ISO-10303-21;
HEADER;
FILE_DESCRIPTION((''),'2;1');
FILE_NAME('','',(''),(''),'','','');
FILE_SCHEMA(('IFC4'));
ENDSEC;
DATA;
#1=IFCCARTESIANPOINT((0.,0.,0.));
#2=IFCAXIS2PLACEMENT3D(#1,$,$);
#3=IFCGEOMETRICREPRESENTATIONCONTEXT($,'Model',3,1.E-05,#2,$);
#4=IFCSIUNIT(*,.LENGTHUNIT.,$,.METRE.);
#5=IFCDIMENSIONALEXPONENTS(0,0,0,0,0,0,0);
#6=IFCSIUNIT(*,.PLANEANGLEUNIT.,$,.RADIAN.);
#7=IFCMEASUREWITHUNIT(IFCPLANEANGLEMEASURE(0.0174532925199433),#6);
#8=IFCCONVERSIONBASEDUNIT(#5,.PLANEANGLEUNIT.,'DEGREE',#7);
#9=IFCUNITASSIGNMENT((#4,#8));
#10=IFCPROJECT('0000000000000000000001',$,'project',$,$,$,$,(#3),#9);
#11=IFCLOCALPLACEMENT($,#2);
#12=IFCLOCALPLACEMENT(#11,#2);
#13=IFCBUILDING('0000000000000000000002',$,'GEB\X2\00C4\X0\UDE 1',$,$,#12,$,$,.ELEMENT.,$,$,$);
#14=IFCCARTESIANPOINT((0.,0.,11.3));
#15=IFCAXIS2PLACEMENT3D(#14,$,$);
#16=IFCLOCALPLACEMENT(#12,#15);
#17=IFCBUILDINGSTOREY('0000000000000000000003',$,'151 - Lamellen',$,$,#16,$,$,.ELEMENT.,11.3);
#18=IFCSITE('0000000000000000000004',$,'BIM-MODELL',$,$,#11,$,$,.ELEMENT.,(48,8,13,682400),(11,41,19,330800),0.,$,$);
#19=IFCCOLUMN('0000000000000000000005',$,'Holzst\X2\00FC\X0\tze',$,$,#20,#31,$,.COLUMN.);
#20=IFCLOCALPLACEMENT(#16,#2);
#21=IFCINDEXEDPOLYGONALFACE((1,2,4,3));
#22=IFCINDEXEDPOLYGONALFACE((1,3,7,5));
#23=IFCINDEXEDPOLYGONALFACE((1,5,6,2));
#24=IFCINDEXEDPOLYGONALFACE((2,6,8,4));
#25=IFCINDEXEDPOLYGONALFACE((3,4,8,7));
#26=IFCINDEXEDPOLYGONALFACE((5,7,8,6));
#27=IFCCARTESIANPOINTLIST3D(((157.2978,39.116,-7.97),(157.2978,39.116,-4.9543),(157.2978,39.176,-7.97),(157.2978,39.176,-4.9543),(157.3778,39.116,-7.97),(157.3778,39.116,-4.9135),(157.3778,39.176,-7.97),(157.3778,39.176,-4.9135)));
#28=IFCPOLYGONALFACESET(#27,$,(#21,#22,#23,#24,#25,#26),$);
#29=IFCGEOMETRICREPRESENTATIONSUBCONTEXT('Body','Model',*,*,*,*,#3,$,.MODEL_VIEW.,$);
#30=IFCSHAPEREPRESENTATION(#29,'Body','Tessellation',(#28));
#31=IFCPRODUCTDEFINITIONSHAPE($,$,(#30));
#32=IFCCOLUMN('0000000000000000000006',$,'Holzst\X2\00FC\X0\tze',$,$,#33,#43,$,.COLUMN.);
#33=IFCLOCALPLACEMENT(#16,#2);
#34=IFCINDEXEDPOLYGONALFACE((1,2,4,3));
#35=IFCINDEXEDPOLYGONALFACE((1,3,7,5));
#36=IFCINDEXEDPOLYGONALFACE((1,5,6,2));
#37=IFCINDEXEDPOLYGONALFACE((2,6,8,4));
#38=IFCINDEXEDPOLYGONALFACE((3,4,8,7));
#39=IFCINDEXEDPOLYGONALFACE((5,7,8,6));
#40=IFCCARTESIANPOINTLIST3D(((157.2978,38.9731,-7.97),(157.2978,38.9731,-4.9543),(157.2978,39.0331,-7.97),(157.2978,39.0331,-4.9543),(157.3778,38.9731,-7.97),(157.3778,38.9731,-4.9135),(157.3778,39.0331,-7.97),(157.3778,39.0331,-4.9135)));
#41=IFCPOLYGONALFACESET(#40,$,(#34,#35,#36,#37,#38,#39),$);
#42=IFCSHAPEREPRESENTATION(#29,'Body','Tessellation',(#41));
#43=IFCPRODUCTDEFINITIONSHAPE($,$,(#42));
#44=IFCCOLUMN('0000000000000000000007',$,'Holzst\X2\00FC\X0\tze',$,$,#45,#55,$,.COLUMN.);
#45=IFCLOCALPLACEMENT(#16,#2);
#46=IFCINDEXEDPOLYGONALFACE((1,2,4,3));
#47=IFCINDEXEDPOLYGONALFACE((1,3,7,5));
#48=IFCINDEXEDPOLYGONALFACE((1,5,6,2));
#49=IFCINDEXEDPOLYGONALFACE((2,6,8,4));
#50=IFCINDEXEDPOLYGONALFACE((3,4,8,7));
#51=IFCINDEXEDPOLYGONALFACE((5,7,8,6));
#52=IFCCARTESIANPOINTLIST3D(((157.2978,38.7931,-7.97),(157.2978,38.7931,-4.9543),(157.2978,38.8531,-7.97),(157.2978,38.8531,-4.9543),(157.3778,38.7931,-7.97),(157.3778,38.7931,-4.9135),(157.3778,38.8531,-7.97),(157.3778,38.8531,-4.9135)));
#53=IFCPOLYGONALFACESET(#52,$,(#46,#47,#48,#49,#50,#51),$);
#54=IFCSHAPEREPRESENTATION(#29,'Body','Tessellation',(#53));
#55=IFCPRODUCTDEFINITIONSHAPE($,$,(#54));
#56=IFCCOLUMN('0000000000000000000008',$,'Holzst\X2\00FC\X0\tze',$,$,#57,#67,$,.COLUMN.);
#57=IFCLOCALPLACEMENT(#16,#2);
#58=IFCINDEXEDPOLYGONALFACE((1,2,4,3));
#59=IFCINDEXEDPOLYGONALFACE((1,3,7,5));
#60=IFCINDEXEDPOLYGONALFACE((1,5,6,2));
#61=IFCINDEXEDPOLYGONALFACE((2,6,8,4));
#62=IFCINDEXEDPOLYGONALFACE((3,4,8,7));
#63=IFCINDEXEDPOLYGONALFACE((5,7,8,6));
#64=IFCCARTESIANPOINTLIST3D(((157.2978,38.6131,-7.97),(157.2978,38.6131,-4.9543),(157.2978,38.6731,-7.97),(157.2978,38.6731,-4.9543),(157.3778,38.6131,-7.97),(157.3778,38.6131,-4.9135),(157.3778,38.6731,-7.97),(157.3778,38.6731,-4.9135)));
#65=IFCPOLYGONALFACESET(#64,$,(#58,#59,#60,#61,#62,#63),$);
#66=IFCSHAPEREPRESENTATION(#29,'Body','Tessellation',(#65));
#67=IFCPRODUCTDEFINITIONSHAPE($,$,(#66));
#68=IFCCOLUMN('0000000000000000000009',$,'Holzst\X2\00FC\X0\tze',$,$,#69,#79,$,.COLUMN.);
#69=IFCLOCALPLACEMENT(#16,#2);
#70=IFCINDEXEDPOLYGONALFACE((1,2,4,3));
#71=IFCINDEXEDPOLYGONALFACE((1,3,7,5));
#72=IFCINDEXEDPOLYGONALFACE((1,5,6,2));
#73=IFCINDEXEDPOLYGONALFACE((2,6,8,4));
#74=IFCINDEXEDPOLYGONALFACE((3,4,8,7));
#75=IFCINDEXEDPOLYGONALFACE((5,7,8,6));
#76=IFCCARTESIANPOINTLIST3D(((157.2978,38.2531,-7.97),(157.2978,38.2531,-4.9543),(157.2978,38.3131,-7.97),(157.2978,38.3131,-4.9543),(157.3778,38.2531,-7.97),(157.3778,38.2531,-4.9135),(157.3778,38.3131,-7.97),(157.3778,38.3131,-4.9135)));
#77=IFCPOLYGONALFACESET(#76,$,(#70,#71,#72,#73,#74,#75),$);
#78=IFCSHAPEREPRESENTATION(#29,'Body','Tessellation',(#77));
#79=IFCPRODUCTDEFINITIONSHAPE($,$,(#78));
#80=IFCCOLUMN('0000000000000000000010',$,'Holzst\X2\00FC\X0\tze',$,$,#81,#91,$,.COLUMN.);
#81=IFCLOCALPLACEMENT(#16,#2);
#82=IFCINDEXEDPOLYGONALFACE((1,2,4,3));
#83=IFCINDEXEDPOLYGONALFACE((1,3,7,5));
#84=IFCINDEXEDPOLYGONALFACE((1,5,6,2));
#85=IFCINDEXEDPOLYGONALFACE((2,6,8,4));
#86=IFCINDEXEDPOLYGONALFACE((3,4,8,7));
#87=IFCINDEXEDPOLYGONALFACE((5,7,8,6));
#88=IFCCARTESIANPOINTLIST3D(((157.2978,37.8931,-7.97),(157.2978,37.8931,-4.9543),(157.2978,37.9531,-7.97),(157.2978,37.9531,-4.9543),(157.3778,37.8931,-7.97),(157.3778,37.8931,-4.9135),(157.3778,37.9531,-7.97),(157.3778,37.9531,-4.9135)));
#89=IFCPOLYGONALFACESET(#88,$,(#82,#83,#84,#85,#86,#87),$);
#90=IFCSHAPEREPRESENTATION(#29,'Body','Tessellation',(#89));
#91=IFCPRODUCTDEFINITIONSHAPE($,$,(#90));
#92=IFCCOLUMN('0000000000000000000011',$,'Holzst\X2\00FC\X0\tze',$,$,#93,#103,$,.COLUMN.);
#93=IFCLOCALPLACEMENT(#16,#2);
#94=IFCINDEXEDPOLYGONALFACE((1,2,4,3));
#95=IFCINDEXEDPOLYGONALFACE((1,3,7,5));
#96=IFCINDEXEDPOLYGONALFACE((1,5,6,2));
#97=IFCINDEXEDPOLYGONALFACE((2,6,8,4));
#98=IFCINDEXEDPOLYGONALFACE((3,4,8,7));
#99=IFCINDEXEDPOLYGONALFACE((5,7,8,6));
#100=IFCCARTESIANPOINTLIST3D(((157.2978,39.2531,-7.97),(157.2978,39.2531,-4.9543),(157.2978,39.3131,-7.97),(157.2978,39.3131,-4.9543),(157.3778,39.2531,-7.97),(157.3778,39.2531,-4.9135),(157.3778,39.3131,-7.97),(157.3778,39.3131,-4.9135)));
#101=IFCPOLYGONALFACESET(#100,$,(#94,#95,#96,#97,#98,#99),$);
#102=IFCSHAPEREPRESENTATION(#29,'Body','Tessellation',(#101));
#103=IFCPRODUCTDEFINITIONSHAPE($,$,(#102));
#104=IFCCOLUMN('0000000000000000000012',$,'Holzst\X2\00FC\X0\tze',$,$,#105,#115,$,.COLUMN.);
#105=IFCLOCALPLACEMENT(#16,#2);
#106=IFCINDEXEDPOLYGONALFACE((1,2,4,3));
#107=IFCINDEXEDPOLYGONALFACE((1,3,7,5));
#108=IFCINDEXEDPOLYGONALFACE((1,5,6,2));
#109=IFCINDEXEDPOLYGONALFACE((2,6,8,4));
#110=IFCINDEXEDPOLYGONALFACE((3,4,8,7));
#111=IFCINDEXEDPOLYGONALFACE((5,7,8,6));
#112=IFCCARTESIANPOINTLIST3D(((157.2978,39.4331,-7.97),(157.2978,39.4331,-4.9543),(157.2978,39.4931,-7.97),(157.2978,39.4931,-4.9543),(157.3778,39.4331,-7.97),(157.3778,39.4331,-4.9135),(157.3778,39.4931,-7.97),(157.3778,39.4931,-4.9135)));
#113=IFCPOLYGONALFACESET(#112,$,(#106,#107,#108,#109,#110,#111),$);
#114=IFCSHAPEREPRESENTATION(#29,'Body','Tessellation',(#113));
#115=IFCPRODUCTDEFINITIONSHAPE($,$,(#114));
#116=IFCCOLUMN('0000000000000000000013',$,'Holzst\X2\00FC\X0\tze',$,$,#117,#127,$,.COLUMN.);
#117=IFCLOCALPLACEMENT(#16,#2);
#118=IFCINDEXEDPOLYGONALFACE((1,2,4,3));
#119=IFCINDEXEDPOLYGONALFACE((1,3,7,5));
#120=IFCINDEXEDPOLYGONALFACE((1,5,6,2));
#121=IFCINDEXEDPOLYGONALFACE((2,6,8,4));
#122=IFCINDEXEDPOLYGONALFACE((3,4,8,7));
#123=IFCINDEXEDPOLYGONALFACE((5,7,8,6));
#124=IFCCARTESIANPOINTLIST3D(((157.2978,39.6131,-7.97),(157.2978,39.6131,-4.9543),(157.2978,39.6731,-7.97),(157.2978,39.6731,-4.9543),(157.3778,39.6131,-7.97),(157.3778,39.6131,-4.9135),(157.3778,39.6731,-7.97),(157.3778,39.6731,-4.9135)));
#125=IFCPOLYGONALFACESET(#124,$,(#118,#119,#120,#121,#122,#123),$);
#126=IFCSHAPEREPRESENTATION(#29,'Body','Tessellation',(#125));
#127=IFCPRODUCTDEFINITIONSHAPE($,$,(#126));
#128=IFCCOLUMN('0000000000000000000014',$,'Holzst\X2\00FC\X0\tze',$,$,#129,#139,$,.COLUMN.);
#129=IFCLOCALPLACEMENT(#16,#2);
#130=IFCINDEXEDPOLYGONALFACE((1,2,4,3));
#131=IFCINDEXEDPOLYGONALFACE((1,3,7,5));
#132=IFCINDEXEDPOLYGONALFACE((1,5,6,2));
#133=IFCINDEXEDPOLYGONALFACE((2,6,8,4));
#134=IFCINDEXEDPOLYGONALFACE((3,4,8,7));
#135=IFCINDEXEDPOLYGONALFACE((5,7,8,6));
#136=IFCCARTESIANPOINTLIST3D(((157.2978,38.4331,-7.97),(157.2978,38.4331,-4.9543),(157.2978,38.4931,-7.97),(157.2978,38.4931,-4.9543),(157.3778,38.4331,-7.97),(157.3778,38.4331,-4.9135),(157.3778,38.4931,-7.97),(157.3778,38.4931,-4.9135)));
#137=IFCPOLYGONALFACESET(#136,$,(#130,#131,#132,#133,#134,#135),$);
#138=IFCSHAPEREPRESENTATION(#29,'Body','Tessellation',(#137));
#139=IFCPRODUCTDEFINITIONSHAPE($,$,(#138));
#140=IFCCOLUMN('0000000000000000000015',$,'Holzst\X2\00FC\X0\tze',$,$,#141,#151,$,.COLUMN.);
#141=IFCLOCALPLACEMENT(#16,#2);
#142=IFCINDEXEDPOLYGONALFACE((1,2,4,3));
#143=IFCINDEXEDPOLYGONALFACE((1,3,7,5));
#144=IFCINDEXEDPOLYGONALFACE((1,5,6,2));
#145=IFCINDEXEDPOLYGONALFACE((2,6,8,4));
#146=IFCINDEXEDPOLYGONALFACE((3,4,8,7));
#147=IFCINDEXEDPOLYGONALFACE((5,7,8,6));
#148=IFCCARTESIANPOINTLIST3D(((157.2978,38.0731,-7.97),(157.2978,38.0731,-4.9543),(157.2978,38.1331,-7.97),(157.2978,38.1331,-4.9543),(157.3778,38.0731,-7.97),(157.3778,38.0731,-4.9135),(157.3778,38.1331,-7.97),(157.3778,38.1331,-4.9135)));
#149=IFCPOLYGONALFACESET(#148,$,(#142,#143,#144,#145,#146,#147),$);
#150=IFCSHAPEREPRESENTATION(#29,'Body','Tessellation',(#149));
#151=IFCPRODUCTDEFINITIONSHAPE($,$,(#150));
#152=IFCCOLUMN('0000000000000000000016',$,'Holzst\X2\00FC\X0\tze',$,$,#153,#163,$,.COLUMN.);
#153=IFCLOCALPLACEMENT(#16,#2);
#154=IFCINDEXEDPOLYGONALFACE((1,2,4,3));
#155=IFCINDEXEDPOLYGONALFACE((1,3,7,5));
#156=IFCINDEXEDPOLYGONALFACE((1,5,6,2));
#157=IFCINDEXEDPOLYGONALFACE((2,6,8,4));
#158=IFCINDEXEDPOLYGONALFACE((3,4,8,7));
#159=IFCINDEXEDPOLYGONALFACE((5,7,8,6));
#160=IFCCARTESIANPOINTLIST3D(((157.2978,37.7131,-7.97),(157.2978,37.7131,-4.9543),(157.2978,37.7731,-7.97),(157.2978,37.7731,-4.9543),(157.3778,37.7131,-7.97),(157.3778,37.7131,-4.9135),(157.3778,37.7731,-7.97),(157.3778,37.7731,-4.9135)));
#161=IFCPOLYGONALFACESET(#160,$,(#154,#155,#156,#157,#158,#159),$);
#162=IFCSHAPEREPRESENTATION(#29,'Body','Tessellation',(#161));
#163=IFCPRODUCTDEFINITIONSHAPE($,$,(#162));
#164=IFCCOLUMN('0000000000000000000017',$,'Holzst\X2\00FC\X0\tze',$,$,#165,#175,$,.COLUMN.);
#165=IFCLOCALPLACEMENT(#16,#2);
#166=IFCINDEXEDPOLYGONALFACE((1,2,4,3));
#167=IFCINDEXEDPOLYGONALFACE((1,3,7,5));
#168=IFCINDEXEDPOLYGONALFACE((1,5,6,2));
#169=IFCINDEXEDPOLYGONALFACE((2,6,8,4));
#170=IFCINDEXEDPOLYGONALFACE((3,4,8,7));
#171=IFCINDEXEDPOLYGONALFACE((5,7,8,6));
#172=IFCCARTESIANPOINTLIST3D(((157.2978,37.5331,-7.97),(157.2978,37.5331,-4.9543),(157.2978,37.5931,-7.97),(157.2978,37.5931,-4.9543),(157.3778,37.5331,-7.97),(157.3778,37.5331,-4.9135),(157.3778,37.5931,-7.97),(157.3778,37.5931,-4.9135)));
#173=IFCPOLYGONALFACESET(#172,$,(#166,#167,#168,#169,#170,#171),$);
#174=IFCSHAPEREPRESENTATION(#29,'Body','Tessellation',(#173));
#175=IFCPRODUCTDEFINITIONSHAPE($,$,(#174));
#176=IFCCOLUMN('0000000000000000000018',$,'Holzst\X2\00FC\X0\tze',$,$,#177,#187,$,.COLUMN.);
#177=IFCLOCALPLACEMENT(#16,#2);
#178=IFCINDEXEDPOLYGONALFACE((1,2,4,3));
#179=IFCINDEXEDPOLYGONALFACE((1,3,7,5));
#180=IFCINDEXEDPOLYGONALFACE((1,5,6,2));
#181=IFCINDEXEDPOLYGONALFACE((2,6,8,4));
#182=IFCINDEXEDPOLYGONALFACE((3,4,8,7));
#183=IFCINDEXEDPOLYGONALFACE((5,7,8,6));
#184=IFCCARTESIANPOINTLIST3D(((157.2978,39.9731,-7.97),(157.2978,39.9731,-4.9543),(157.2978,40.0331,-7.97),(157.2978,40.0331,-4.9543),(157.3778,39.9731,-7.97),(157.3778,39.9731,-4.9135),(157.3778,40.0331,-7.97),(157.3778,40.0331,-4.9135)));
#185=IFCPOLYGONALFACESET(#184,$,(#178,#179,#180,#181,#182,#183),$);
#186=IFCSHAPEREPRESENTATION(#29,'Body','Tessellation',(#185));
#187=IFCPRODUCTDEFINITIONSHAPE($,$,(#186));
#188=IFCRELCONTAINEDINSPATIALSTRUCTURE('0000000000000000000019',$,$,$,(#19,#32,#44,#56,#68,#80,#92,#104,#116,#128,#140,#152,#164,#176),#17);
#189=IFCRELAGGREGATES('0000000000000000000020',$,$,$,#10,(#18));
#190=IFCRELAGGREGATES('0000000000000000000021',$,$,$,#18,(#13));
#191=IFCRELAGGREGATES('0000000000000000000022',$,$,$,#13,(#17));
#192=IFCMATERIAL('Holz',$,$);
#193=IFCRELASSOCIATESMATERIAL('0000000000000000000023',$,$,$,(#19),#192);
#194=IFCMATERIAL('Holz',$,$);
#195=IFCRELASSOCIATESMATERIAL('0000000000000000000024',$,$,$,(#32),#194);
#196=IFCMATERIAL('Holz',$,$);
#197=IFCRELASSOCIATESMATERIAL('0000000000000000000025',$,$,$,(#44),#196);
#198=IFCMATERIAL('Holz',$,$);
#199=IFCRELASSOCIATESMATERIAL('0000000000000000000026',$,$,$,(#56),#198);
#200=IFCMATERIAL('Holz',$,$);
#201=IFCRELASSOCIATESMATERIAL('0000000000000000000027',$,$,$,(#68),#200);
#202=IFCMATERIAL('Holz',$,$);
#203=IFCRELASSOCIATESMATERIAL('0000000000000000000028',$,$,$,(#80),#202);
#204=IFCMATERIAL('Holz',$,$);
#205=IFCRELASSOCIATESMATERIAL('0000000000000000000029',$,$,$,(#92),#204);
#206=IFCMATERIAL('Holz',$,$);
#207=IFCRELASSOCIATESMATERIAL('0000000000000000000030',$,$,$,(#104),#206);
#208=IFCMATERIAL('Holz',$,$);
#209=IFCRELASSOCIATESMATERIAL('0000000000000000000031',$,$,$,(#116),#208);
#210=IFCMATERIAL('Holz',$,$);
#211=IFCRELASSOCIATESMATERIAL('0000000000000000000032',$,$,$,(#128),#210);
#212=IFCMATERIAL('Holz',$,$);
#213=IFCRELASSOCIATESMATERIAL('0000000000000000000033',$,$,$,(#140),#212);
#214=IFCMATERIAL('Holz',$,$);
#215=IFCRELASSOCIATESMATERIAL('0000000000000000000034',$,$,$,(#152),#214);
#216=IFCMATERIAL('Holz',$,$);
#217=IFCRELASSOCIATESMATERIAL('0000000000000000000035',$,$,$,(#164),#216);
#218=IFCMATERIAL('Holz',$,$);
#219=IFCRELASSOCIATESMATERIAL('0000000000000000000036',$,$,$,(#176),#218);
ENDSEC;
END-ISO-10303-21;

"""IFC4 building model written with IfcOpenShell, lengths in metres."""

from ifc_helpers import new_model, entity, si_unit, converted_unit, frame, frame_2d, origin, origin_with_axes, place, context, subcontext, project, spatial, rectangle, extrude, clip, halfspace, material, element, save


model = new_model("IFC4")

# Units and contexts
model_context = context("Model", 3, precision=1e-05, world=origin())
body_context = subcontext(model_context, "Body", "Model", "MODEL_VIEW")
ifc_project = project(units=[si_unit("LENGTHUNIT", "METRE"), converted_unit("PLANEANGLEUNIT", "DEGREE", entity("IfcPlaneAngleMeasure", 0.0174532925199433), si_unit("PLANEANGLEUNIT", "RADIAN"), dimensions=[0, 0, 0, 0, 0, 0, 0])], contexts=[model_context])

# Site, building, storey
site_placement = place(None, origin())
site = spatial("IfcSite", under=ifc_project, at=site_placement, Name="BIM-MODELL", CompositionType="ELEMENT", RefLatitude=(48, 8, 13, 682400), RefLongitude=(11, 41, 19, 330800), RefElevation=0.0)
building_placement = place(site_placement, origin())
building = spatial("IfcBuilding", under=site, at=building_placement, Name="GEBÄUDE 1", CompositionType="ELEMENT")
storey_placement = place(building_placement, frame((0.0, 0.0, 11.3)))
storey = spatial("IfcBuildingStorey", under=building, at=storey_placement, Name="151 - Lamellen", CompositionType="ELEMENT", Elevation=11.3)

# Columns
ifc_material_1 = material(Name="Holz")
column_1_placement = place(storey_placement, frame((157.3778, 39.116, -7.97)))
element("IfcColumn", 1, at=column_1_placement, inside=storey, material=ifc_material_1, Name="Holzstütze", PredefinedType="COLUMN", context=body_context, shape_type="Clipping", body=[
    clip(extrude(rectangle(XDim=0.06, YDim=0.08, at=frame_2d((-0.04, 0.03), x_axis=(0.0, 1.0))), origin_with_axes(), (0.0, 0.0, 1.0), 3.0565), halfspace(frame((-0.04, 0.03, 3.0361), z_axis=(0.45399, 0.0, -0.891007), x_axis=(-0.891007, 0.0, -0.45399)), True)),
])
ifc_material_2 = material(Name="Holz")
column_2_placement = place(storey_placement, frame((157.3778, 38.9731, -7.97)))
element("IfcColumn", 2, at=column_2_placement, inside=storey, material=ifc_material_2, Name="Holzstütze", PredefinedType="COLUMN", context=body_context, shape_type="Clipping", body=[
    clip(extrude(rectangle(XDim=0.06, YDim=0.08, at=frame_2d((-0.04, 0.03), x_axis=(0.0, 1.0))), origin_with_axes(), (0.0, 0.0, 1.0), 3.0565), halfspace(frame((-0.04, 0.03, 3.0361), z_axis=(0.45399, 0.0, -0.891007), x_axis=(-0.891007, 0.0, -0.45399)), True)),
])
ifc_material_3 = material(Name="Holz")
column_3_placement = place(storey_placement, frame((157.3778, 38.7931, -7.97)))
element("IfcColumn", 3, at=column_3_placement, inside=storey, material=ifc_material_3, Name="Holzstütze", PredefinedType="COLUMN", context=body_context, shape_type="Clipping", body=[
    clip(extrude(rectangle(XDim=0.06, YDim=0.08, at=frame_2d((-0.04, 0.03), x_axis=(0.0, 1.0))), origin_with_axes(), (0.0, 0.0, 1.0), 3.0565), halfspace(frame((-0.04, 0.03, 3.0361), z_axis=(0.45399, 0.0, -0.891007), x_axis=(-0.891007, 0.0, -0.45399)), True)),
])
ifc_material_4 = material(Name="Holz")
column_4_placement = place(storey_placement, frame((157.3778, 38.6131, -7.97)))
element("IfcColumn", 4, at=column_4_placement, inside=storey, material=ifc_material_4, Name="Holzstütze", PredefinedType="COLUMN", context=body_context, shape_type="Clipping", body=[
    clip(extrude(rectangle(XDim=0.06, YDim=0.08, at=frame_2d((-0.04, 0.03), x_axis=(0.0, 1.0))), origin_with_axes(), (0.0, 0.0, 1.0), 3.0565), halfspace(frame((-0.04, 0.03, 3.0361), z_axis=(0.45399, 0.0, -0.891007), x_axis=(-0.891007, 0.0, -0.45399)), True)),
])
ifc_material_5 = material(Name="Holz")
column_5_placement = place(storey_placement, frame((157.3778, 38.2531, -7.97)))
element("IfcColumn", 5, at=column_5_placement, inside=storey, material=ifc_material_5, Name="Holzstütze", PredefinedType="COLUMN", context=body_context, shape_type="Clipping", body=[
    clip(extrude(rectangle(XDim=0.06, YDim=0.08, at=frame_2d((-0.04, 0.03), x_axis=(0.0, 1.0))), origin_with_axes(), (0.0, 0.0, 1.0), 3.0565), halfspace(frame((-0.04, 0.03, 3.0361), z_axis=(0.45399, 0.0, -0.891007), x_axis=(-0.891007, 0.0, -0.45399)), True)),
])
ifc_material_6 = material(Name="Holz")
column_6_placement = place(storey_placement, frame((157.3778, 37.8931, -7.97)))
element("IfcColumn", 6, at=column_6_placement, inside=storey, material=ifc_material_6, Name="Holzstütze", PredefinedType="COLUMN", context=body_context, shape_type="Clipping", body=[
    clip(extrude(rectangle(XDim=0.06, YDim=0.08, at=frame_2d((-0.04, 0.03), x_axis=(0.0, 1.0))), origin_with_axes(), (0.0, 0.0, 1.0), 3.0565), halfspace(frame((-0.04, 0.03, 3.0361), z_axis=(0.45399, 0.0, -0.891007), x_axis=(-0.891007, 0.0, -0.45399)), True)),
])
ifc_material_7 = material(Name="Holz")
column_7_placement = place(storey_placement, frame((157.3778, 39.2531, -7.97)))
element("IfcColumn", 7, at=column_7_placement, inside=storey, material=ifc_material_7, Name="Holzstütze", PredefinedType="COLUMN", context=body_context, shape_type="Clipping", body=[
    clip(extrude(rectangle(XDim=0.06, YDim=0.08, at=frame_2d((-0.04, 0.03), x_axis=(0.0, 1.0))), origin_with_axes(), (0.0, 0.0, 1.0), 3.0565), halfspace(frame((-0.04, 0.03, 3.0361), z_axis=(0.45399, 0.0, -0.891007), x_axis=(-0.891007, 0.0, -0.45399)), True)),
])
ifc_material_8 = material(Name="Holz")
column_8_placement = place(storey_placement, frame((157.3778, 39.4331, -7.97)))
element("IfcColumn", 8, at=column_8_placement, inside=storey, material=ifc_material_8, Name="Holzstütze", PredefinedType="COLUMN", context=body_context, shape_type="Clipping", body=[
    clip(extrude(rectangle(XDim=0.06, YDim=0.08, at=frame_2d((-0.04, 0.03), x_axis=(0.0, 1.0))), origin_with_axes(), (0.0, 0.0, 1.0), 3.0565), halfspace(frame((-0.04, 0.03, 3.0361), z_axis=(0.45399, 0.0, -0.891007), x_axis=(-0.891007, 0.0, -0.45399)), True)),
])
ifc_material_9 = material(Name="Holz")
column_9_placement = place(storey_placement, frame((157.3778, 39.6131, -7.97)))
element("IfcColumn", 9, at=column_9_placement, inside=storey, material=ifc_material_9, Name="Holzstütze", PredefinedType="COLUMN", context=body_context, shape_type="Clipping", body=[
    clip(extrude(rectangle(XDim=0.06, YDim=0.08, at=frame_2d((-0.04, 0.03), x_axis=(0.0, 1.0))), origin_with_axes(), (0.0, 0.0, 1.0), 3.0565), halfspace(frame((-0.04, 0.03, 3.0361), z_axis=(0.45399, 0.0, -0.891007), x_axis=(-0.891007, 0.0, -0.45399)), True)),
])
ifc_material_10 = material(Name="Holz")
column_10_placement = place(storey_placement, frame((157.3778, 38.4331, -7.97)))
element("IfcColumn", 10, at=column_10_placement, inside=storey, material=ifc_material_10, Name="Holzstütze", PredefinedType="COLUMN", context=body_context, shape_type="Clipping", body=[
    clip(extrude(rectangle(XDim=0.06, YDim=0.08, at=frame_2d((-0.04, 0.03), x_axis=(0.0, 1.0))), origin_with_axes(), (0.0, 0.0, 1.0), 3.0565), halfspace(frame((-0.04, 0.03, 3.0361), z_axis=(0.45399, 0.0, -0.891007), x_axis=(-0.891007, 0.0, -0.45399)), True)),
])
ifc_material_11 = material(Name="Holz")
column_11_placement = place(storey_placement, frame((157.3778, 38.0731, -7.97)))
element("IfcColumn", 11, at=column_11_placement, inside=storey, material=ifc_material_11, Name="Holzstütze", PredefinedType="COLUMN", context=body_context, shape_type="Clipping", body=[
    clip(extrude(rectangle(XDim=0.06, YDim=0.08, at=frame_2d((-0.04, 0.03), x_axis=(0.0, 1.0))), origin_with_axes(), (0.0, 0.0, 1.0), 3.0565), halfspace(frame((-0.04, 0.03, 3.0361), z_axis=(0.45399, 0.0, -0.891007), x_axis=(-0.891007, 0.0, -0.45399)), True)),
])
ifc_material_12 = material(Name="Holz")
column_12_placement = place(storey_placement, frame((157.3778, 37.7131, -7.97)))
element("IfcColumn", 12, at=column_12_placement, inside=storey, material=ifc_material_12, Name="Holzstütze", PredefinedType="COLUMN", context=body_context, shape_type="Clipping", body=[
    clip(extrude(rectangle(XDim=0.06, YDim=0.08, at=frame_2d((-0.04, 0.03), x_axis=(0.0, 1.0))), origin_with_axes(), (0.0, 0.0, 1.0), 3.0565), halfspace(frame((-0.04, 0.03, 3.0361), z_axis=(0.45399, 0.0, -0.891007), x_axis=(-0.891007, 0.0, -0.45399)), True)),
])
ifc_material_13 = material(Name="Holz")
column_13_placement = place(storey_placement, frame((157.3778, 37.5331, -7.97)))
element("IfcColumn", 13, at=column_13_placement, inside=storey, material=ifc_material_13, Name="Holzstütze", PredefinedType="COLUMN", context=body_context, shape_type="Clipping", body=[
    clip(extrude(rectangle(XDim=0.06, YDim=0.08, at=frame_2d((-0.04, 0.03), x_axis=(0.0, 1.0))), origin_with_axes(), (0.0, 0.0, 1.0), 3.0565), halfspace(frame((-0.04, 0.03, 3.0361), z_axis=(0.45399, 0.0, -0.891007), x_axis=(-0.891007, 0.0, -0.45399)), True)),
])
ifc_material_14 = material(Name="Holz")
column_14_placement = place(storey_placement, frame((157.3778, 39.9731, -7.97)))
element("IfcColumn", 14, at=column_14_placement, inside=storey, material=ifc_material_14, Name="Holzstütze", PredefinedType="COLUMN", context=body_context, shape_type="Clipping", body=[
    clip(extrude(rectangle(XDim=0.06, YDim=0.08, at=frame_2d((-0.04, 0.03), x_axis=(0.0, 1.0))), origin_with_axes(), (0.0, 0.0, 1.0), 3.0565), halfspace(frame((-0.04, 0.03, 3.0361), z_axis=(0.45399, 0.0, -0.891007), x_axis=(-0.891007, 0.0, -0.45399)), True)),
])

save(model, "model.ifc")
